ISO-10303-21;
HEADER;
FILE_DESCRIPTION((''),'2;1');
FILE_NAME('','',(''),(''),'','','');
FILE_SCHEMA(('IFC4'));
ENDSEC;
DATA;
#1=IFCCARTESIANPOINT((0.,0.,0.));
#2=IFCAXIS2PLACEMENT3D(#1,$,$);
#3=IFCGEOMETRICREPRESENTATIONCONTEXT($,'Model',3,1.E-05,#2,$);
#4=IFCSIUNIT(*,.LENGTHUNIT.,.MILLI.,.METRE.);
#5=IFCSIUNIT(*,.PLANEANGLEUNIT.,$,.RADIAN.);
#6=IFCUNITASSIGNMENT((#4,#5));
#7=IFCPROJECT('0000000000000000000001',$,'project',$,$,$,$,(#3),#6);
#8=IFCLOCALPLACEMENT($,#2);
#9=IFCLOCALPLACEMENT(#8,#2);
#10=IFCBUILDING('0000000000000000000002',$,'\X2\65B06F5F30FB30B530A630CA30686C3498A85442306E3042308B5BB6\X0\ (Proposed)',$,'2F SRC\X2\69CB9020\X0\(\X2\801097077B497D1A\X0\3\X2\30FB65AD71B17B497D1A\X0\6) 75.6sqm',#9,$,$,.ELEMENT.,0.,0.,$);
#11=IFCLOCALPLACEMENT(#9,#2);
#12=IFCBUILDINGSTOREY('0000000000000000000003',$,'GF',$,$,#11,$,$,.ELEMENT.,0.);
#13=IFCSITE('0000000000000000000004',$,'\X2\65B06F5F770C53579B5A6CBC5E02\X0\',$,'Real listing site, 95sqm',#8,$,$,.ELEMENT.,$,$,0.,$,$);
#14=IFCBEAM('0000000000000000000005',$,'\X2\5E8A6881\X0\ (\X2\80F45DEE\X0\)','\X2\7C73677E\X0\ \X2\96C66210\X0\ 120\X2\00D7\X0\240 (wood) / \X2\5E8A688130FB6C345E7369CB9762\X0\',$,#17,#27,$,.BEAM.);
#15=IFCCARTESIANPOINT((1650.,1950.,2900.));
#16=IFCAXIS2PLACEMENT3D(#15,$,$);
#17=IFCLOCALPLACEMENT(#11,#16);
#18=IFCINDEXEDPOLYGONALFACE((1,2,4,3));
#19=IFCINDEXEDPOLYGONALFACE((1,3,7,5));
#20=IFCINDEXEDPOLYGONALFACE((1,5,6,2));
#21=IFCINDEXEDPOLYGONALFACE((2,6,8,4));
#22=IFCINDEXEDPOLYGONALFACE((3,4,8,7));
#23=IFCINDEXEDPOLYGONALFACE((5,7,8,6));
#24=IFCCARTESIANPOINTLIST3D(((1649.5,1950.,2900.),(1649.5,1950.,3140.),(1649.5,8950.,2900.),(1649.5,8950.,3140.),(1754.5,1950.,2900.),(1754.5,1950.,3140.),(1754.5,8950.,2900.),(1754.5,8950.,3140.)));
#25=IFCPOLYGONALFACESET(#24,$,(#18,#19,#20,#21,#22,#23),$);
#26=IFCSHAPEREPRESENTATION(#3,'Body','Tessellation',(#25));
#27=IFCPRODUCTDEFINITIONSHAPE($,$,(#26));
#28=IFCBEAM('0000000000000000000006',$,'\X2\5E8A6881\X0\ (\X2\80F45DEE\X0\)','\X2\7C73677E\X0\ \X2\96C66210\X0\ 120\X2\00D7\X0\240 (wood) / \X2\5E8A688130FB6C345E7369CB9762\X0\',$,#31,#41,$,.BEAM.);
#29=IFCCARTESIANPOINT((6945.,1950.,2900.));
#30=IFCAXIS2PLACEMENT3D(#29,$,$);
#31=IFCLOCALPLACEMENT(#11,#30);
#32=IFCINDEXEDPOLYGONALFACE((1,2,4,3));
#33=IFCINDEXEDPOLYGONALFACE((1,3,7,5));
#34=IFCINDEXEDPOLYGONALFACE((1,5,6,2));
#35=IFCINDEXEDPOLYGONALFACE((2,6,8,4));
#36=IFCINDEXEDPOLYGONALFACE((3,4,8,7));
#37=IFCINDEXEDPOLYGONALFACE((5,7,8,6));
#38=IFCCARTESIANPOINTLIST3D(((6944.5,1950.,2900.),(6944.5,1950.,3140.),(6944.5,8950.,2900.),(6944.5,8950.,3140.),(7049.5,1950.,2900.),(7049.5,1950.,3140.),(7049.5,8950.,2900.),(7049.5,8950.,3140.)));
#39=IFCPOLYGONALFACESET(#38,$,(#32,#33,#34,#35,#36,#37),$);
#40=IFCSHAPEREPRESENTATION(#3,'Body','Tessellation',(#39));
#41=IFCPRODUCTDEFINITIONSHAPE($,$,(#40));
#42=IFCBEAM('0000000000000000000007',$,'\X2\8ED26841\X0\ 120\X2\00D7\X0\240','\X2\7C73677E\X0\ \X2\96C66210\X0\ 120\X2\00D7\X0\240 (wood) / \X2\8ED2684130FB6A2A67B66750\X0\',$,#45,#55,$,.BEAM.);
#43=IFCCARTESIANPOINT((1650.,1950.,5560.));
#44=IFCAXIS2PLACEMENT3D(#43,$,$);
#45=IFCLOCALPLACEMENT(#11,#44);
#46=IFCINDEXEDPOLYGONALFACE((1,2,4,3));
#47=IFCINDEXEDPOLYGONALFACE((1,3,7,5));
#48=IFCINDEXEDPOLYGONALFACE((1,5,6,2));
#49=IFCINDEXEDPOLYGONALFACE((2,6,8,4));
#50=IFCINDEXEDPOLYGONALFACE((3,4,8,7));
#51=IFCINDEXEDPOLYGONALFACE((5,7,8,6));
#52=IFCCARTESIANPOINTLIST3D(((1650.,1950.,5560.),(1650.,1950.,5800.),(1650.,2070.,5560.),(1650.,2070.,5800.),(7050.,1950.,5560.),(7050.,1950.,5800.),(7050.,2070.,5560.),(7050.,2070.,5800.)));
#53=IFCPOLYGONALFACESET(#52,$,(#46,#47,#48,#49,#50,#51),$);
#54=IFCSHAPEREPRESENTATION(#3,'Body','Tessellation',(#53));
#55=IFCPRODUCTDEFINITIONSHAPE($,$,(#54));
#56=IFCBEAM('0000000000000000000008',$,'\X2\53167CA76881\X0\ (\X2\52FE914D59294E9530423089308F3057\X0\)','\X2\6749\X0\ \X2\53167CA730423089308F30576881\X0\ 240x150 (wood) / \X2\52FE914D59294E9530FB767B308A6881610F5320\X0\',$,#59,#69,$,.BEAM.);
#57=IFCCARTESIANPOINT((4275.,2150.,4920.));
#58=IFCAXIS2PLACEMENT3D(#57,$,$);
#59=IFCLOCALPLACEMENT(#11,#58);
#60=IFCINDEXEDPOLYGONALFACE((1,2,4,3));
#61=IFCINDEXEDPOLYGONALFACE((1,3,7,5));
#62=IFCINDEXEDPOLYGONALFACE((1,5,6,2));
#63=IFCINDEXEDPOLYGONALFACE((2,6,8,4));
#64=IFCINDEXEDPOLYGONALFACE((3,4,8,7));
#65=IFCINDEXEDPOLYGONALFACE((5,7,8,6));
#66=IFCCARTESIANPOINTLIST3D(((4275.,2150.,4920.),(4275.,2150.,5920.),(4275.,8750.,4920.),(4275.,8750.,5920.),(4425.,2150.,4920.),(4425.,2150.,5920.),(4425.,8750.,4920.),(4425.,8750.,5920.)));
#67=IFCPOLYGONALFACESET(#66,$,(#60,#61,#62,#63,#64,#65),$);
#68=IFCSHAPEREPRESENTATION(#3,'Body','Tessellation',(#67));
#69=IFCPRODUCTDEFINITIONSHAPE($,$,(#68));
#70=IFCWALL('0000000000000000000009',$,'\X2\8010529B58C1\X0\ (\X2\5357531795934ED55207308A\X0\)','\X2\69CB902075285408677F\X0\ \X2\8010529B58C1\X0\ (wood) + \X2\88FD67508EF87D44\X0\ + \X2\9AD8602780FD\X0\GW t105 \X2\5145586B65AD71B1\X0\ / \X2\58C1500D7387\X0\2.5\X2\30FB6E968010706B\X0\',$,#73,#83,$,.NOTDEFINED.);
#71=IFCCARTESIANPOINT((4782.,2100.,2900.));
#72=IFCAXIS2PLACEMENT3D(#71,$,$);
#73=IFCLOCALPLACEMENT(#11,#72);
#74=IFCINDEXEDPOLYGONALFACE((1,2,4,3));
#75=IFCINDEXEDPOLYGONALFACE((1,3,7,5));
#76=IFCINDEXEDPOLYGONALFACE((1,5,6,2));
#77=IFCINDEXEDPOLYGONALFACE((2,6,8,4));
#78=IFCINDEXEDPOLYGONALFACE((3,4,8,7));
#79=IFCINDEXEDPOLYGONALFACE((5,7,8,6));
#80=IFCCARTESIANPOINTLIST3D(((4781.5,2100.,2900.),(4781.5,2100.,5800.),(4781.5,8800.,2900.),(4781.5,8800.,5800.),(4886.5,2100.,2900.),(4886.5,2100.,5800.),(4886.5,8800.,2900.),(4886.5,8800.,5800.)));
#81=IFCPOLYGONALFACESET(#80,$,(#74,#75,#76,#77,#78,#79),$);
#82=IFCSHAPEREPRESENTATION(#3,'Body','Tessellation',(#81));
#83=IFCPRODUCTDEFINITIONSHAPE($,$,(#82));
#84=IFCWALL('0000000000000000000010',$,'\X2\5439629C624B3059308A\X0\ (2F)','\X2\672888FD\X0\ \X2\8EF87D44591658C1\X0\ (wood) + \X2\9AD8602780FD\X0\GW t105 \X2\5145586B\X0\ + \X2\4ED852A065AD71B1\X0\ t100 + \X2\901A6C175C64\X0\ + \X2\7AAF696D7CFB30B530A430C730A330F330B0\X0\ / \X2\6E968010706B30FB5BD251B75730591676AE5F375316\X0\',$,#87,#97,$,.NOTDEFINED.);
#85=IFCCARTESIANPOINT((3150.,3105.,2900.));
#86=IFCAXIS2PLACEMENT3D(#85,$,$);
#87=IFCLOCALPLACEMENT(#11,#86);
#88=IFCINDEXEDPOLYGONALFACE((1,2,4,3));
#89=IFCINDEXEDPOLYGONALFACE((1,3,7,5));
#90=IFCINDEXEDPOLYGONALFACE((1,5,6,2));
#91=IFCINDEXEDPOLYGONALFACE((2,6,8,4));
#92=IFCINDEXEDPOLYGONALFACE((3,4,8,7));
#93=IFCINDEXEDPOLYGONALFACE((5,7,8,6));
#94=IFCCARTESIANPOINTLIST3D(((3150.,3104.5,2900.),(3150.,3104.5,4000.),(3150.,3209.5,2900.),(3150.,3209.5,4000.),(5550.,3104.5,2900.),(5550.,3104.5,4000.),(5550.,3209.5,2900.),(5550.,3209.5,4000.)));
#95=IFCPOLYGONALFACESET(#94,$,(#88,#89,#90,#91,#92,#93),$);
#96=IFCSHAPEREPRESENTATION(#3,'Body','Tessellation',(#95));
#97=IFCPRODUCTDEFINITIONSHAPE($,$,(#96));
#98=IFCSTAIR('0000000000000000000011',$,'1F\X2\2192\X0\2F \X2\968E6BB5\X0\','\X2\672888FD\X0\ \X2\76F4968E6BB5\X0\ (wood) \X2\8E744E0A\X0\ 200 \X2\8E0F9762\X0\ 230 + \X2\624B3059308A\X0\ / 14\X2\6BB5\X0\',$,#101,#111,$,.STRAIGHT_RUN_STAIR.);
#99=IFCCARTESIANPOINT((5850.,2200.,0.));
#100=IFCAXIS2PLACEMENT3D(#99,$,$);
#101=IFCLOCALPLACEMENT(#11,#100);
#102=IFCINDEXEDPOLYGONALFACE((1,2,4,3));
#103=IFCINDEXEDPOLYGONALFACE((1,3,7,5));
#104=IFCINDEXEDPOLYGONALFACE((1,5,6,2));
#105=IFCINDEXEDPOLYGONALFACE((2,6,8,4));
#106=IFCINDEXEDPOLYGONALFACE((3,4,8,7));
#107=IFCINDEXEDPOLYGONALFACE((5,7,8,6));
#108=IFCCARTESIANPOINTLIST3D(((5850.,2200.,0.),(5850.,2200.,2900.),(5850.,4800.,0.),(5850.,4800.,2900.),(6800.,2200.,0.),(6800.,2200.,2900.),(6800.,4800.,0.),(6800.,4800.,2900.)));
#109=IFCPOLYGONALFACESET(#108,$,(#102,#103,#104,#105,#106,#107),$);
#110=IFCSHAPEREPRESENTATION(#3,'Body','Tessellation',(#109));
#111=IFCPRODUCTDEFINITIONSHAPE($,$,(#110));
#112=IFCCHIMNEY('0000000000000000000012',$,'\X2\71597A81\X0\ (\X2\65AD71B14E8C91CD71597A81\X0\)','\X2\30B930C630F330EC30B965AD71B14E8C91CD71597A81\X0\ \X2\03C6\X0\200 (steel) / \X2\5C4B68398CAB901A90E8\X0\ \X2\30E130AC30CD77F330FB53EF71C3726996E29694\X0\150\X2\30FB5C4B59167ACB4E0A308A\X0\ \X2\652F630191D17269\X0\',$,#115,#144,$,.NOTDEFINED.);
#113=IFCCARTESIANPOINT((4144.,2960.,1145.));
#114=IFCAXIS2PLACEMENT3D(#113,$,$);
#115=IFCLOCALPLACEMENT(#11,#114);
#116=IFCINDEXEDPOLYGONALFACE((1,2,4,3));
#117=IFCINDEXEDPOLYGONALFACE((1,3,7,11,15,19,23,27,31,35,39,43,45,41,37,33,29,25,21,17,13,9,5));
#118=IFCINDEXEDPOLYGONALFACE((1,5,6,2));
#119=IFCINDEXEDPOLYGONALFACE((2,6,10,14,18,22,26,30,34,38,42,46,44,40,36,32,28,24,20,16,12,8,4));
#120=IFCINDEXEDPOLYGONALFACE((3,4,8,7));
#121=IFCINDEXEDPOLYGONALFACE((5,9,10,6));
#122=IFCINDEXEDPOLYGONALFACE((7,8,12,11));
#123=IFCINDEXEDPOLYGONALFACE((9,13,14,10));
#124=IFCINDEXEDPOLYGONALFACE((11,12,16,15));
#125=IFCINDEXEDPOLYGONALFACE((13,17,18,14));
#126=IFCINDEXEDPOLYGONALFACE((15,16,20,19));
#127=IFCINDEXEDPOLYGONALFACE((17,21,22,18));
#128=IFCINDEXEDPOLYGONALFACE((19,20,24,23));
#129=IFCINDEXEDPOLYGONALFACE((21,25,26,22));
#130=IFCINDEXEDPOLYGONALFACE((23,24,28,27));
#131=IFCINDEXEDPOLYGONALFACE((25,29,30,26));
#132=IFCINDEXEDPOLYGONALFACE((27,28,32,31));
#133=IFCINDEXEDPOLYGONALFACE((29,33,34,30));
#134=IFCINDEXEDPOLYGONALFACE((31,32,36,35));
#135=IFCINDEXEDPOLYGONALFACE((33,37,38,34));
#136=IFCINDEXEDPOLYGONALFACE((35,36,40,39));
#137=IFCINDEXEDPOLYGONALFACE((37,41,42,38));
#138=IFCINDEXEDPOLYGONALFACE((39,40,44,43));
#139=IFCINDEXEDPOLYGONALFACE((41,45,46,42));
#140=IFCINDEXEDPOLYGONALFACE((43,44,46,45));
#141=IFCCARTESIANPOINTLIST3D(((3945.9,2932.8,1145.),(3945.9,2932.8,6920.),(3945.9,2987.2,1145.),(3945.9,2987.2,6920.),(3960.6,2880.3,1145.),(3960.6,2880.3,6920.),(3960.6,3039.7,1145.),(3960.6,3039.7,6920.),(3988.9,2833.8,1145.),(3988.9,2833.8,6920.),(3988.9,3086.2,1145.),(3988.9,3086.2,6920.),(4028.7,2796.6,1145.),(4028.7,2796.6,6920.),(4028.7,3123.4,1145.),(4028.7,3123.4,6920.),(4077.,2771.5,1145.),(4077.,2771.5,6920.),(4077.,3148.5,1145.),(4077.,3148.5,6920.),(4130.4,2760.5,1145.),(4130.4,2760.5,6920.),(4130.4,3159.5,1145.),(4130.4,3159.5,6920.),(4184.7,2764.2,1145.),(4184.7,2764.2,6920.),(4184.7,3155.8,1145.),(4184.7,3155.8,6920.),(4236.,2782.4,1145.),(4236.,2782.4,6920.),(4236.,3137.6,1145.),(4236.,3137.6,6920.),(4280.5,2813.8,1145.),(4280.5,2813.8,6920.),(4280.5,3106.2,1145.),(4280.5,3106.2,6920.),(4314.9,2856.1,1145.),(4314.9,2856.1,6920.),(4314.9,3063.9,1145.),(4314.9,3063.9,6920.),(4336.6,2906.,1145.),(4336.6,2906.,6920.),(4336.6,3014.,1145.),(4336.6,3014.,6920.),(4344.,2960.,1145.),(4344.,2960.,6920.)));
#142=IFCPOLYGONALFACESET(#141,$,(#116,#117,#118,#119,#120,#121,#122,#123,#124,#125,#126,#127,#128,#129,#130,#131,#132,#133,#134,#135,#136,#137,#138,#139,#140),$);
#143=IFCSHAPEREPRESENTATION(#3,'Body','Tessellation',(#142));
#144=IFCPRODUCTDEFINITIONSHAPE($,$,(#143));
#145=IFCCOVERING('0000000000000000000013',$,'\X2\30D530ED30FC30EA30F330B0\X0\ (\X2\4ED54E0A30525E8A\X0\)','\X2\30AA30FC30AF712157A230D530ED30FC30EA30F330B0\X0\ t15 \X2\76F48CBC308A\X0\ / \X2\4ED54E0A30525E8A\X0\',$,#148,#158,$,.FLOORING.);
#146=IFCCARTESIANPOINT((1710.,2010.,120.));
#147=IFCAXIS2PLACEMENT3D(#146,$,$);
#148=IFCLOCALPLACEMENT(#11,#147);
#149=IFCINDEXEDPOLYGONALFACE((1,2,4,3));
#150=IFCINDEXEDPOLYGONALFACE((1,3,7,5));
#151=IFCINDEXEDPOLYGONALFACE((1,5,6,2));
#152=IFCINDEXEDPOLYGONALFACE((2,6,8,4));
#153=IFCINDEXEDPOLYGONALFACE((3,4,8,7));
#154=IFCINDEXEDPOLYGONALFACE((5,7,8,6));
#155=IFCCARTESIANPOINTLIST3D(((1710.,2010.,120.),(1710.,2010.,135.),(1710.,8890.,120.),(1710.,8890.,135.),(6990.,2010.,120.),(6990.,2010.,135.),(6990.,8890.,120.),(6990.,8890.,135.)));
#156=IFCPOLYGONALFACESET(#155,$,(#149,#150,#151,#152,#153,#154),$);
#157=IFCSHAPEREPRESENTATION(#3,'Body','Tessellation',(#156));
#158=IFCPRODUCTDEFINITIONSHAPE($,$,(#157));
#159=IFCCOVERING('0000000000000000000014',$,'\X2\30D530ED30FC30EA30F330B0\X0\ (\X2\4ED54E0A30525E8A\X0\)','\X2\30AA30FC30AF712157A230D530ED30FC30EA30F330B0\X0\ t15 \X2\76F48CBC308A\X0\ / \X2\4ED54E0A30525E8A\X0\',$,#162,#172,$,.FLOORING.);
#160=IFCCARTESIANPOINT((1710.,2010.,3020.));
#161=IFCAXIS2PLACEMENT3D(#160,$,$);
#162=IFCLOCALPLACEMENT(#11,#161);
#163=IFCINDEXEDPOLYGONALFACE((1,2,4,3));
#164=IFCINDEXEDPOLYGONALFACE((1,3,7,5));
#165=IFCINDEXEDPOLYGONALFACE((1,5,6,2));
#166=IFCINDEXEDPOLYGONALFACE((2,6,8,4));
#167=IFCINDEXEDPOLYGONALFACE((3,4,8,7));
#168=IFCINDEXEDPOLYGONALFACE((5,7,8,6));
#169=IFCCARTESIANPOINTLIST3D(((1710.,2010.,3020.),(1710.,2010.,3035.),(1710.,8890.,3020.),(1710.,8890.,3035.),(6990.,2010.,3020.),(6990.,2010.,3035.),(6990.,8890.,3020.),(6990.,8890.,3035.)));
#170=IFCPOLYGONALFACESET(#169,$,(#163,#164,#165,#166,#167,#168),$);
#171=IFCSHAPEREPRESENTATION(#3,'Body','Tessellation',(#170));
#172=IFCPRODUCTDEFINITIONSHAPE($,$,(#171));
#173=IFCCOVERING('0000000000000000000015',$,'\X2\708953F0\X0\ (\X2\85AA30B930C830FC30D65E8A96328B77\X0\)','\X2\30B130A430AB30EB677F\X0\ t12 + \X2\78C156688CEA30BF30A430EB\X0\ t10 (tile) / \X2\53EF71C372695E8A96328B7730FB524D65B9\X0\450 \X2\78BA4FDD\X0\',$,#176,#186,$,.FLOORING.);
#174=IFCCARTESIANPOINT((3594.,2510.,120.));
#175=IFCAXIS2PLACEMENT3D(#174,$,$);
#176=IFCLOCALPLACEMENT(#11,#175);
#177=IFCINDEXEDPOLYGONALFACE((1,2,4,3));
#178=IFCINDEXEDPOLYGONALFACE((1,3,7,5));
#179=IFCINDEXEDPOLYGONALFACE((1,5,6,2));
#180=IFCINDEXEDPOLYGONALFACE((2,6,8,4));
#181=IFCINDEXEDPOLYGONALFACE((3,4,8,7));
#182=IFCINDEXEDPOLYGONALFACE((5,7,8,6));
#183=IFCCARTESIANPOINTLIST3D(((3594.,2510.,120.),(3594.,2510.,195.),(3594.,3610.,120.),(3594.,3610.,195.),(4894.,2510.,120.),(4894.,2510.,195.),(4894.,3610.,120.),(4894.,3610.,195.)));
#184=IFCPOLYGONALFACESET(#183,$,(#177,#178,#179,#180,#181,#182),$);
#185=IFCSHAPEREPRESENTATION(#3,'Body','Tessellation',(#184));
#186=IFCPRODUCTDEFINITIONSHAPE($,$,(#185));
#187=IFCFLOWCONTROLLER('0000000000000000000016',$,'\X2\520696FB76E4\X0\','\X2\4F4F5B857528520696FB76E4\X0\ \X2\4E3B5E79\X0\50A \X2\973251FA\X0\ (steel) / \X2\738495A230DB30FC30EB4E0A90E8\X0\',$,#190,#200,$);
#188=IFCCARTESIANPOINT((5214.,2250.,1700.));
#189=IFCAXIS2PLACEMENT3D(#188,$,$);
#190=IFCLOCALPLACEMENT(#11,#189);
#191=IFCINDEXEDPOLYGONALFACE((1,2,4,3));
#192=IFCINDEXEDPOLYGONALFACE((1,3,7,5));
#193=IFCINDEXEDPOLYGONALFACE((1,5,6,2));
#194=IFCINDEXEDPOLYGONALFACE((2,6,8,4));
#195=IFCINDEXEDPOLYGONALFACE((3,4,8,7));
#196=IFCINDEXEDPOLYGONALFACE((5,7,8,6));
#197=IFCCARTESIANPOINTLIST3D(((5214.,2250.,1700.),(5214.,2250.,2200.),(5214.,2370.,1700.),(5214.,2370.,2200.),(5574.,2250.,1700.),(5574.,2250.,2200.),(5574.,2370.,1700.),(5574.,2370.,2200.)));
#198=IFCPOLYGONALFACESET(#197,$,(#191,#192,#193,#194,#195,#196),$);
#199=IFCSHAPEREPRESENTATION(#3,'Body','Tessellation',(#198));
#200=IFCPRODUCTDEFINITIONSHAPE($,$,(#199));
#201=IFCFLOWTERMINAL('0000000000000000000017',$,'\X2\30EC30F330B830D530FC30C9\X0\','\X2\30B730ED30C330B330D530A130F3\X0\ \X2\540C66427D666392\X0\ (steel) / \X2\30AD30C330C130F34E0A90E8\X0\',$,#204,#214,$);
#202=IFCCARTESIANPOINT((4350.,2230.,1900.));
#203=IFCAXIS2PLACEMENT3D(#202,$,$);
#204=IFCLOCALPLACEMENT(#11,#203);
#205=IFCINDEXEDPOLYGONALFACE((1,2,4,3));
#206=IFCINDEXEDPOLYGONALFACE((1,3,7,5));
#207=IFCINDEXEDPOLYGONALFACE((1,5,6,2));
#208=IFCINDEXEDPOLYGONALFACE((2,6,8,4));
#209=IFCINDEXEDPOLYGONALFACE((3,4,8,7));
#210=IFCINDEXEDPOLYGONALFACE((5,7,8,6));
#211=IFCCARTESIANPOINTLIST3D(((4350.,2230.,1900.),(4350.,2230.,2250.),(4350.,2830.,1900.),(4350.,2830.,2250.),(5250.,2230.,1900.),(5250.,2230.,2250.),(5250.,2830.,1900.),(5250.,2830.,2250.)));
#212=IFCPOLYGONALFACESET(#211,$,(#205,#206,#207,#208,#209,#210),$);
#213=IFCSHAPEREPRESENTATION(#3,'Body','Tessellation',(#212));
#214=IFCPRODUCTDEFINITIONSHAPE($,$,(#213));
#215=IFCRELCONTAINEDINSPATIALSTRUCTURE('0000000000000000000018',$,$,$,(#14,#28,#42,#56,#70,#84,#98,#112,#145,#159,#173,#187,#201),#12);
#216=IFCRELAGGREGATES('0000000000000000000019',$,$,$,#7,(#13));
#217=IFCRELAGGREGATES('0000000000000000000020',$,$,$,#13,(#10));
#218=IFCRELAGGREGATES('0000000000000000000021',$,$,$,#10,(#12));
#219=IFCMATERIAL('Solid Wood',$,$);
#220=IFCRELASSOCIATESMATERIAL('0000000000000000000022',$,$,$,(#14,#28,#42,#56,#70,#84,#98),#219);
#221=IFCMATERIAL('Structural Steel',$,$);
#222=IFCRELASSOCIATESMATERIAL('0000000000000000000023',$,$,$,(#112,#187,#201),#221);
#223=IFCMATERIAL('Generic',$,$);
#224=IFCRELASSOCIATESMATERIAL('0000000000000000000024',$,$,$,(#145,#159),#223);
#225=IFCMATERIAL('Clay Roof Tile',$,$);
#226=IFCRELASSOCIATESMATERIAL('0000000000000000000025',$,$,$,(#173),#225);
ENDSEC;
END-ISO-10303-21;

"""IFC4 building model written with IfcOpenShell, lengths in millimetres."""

from ifc_helpers import new_model, si_unit, frame, frame_2d, origin, origin_2d, place, context, project, spatial, rectangle, circle, extrude, material, element, save


model = new_model("IFC4")

# Units and contexts
model_context = context("Model", 3, precision=1e-05, world=origin())
ifc_project = project(units=[si_unit("LENGTHUNIT", "METRE", prefix="MILLI"), si_unit("PLANEANGLEUNIT", "RADIAN")], contexts=[model_context])

# Site, building, storey
site_placement = place(None, origin())
site = spatial("IfcSite", under=ifc_project, at=site_placement, Name="新潟県南魚沼市", ObjectType="Real listing site, 95sqm", CompositionType="ELEMENT", RefElevation=0.0)
building_placement = place(site_placement, origin())
building = spatial("IfcBuilding", under=site, at=building_placement, Name="新潟・サウナと水風呂のある家 (Proposed)", ObjectType="2F SRC構造(耐震等級3・断熱等級6) 75.6sqm", CompositionType="ELEMENT", ElevationOfRefHeight=0.0, ElevationOfTerrain=0.0)
storey_placement = place(building_placement, origin())
storey = spatial("IfcBuildingStorey", under=building, at=storey_placement, Name="GF", CompositionType="ELEMENT", Elevation=0.0)

# Beams
ifc_material_1 = material(Name="Solid Wood")
beam_1_placement = place(storey_placement, frame((1650.0, 1950.0, 2900.0)))
element("IfcBeam", 1, at=beam_1_placement, inside=storey, material=ifc_material_1, Name="床梁 (胴差)", Description="米松 集成 120×240 (wood) / 床梁・水平構面", PredefinedType="BEAM", context=model_context, shape_type="SweptSolid", body=[
    extrude(rectangle(XDim=105.0, YDim=7000.0, at=frame_2d((52.0, 3500.0))), frame((1650.0, 1950.0, 2900.0)), (0.0, 0.0, 1.0), 240.0),
])
beam_2_placement = place(storey_placement, frame((6945.0, 1950.0, 2900.0)))
element("IfcBeam", 2, at=beam_2_placement, inside=storey, material=ifc_material_1, Name="床梁 (胴差)", Description="米松 集成 120×240 (wood) / 床梁・水平構面", PredefinedType="BEAM", context=model_context, shape_type="SweptSolid", body=[
    extrude(rectangle(XDim=105.0, YDim=7000.0, at=frame_2d((52.0, 3500.0))), frame((6945.0, 1950.0, 2900.0)), (0.0, 0.0, 1.0), 240.0),
])
beam_3_placement = place(storey_placement, frame((1650.0, 1950.0, 5560.0)))
element("IfcBeam", 3, at=beam_3_placement, inside=storey, material=ifc_material_1, Name="軒桁 120×240", Description="米松 集成 120×240 (wood) / 軒桁・横架材", PredefinedType="BEAM", context=model_context, shape_type="SweptSolid", body=[
    extrude(rectangle(XDim=5400.0, YDim=120.0, at=frame_2d((2700.0, 60.0))), frame((1650.0, 1950.0, 5560.0)), (0.0, 0.0, 1.0), 240.0),
])
beam_4_placement = place(storey_placement, frame((4275.0, 2150.0, 4920.0)))
element("IfcBeam", 4, at=beam_4_placement, inside=storey, material=ifc_material_1, Name="化粧梁 (勾配天井あらわし)", Description="杉 化粧あらわし梁 240x150 (wood) / 勾配天井・登り梁意匠", PredefinedType="BEAM", context=model_context, shape_type="SweptSolid", body=[
    extrude(rectangle(XDim=150.0, YDim=6600.0, at=frame_2d((75.0, 3300.0))), frame((4275.0, 2150.0, 4920.0)), (0.0, 0.0, 1.0), 1000.0),
])

# Walls
wall_1_placement = place(storey_placement, frame((4782.0, 2100.0, 2900.0)))
element("IfcWall", 5, at=wall_1_placement, inside=storey, material=ifc_material_1, Name="耐力壁 (南北間仕切り)", Description="構造用合板 耐力壁 (wood) + 製材軸組 + 高性能GW t105 充填断熱 / 壁倍率2.5・準耐火", PredefinedType="NOTDEFINED", context=model_context, shape_type="SweptSolid", body=[
    extrude(rectangle(XDim=105.0, YDim=6700.0, at=frame_2d((52.0, 3350.0))), frame((4782.0, 2100.0, 2900.0)), (0.0, 0.0, 1.0), 2900.0),
])
wall_2_placement = place(storey_placement, frame((3150.0, 3105.0, 2900.0)))
element("IfcWall", 6, at=wall_2_placement, inside=storey, material=ifc_material_1, Name="吹抜手すり (2F)", Description="木製 軸組外壁 (wood) + 高性能GW t105 充填 + 付加断熱 t100 + 通気層 + 窯業系サイディング / 準耐火・寒冷地外皮強化", PredefinedType="NOTDEFINED", context=model_context, shape_type="SweptSolid", body=[
    extrude(rectangle(XDim=2400.0, YDim=105.0, at=frame_2d((1200.0, 52.0))), frame((3150.0, 3105.0, 2900.0)), (0.0, 0.0, 1.0), 1100.0),
])

# Stair
stair_placement = place(storey_placement, frame((5850.0, 2200.0, 0.0)))
element("IfcStair", 7, at=stair_placement, inside=storey, material=ifc_material_1, Name="1F→2F 階段", Description="木製 直階段 (wood) 蹴上 200 踏面 230 + 手すり / 14段", PredefinedType="STRAIGHT_RUN_STAIR", context=model_context, shape_type="SweptSolid", body=[
    extrude(rectangle(XDim=950.0, YDim=2600.0, at=frame_2d((475.0, 1300.0))), frame((5850.0, 2200.0, 0.0)), (0.0, 0.0, 1.0), 2900.0),
])

# Chimney
ifc_material_2 = material(Name="Structural Steel")
chimney_placement = place(storey_placement, frame((4144.0, 2960.0, 1145.0)))
element("IfcChimney", 8, at=chimney_placement, inside=storey, material=ifc_material_2, Name="煙突 (断熱二重煙突)", Description="ステンレス断熱二重煙突 φ200 (steel) / 屋根貫通部 メガネ石・可燃物離隔150・屋外立上り 支持金物", PredefinedType="NOTDEFINED", context=model_context, shape_type="SweptSolid", body=[
    extrude(circle(Radius=200.0, at=origin_2d()), frame((4144.0, 2960.0, 1145.0)), (0.0, 0.0, 1.0), 5775.0),
])

# Coverings
ifc_material_3 = material(Name="Generic")
covering_1_placement = place(storey_placement, frame((1710.0, 2010.0, 120.0)))
element("IfcCovering", 9, at=covering_1_placement, inside=storey, material=ifc_material_3, Name="フローリング (仕上げ床)", Description="オーク無垢フローリング t15 直貼り / 仕上げ床", PredefinedType="FLOORING", context=model_context, shape_type="SweptSolid", body=[
    extrude(rectangle(XDim=5280.0, YDim=6880.0, at=frame_2d((2640.0, 3440.0))), frame((1710.0, 2010.0, 120.0)), (0.0, 0.0, 1.0), 15.0),
])
covering_2_placement = place(storey_placement, frame((1710.0, 2010.0, 3020.0)))
element("IfcCovering", 10, at=covering_2_placement, inside=storey, material=ifc_material_3, Name="フローリング (仕上げ床)", Description="オーク無垢フローリング t15 直貼り / 仕上げ床", PredefinedType="FLOORING", context=model_context, shape_type="SweptSolid", body=[
    extrude(rectangle(XDim=5280.0, YDim=6880.0, at=frame_2d((2640.0, 3440.0))), frame((1710.0, 2010.0, 3020.0)), (0.0, 0.0, 1.0), 15.0),
])
ifc_material_4 = material(Name="Clay Roof Tile")
covering_3_placement = place(storey_placement, frame((3594.0, 2510.0, 120.0)))
element("IfcCovering", 11, at=covering_3_placement, inside=storey, material=ifc_material_4, Name="炉台 (薪ストーブ床防護)", Description="ケイカル板 t12 + 磁器質タイル t10 (tile) / 可燃物床防護・前方450 確保", PredefinedType="FLOORING", context=model_context, shape_type="SweptSolid", body=[
    extrude(rectangle(XDim=1300.0, YDim=1100.0, at=frame_2d((650.0, 550.0))), frame((3594.0, 2510.0, 120.0)), (0.0, 0.0, 1.0), 75.0),
])

# Flow controller
flow_controller_placement = place(storey_placement, frame((5214.0, 2250.0, 1700.0)))
element("IfcFlowController", 12, at=flow_controller_placement, inside=storey, material=ifc_material_2, Name="分電盤", Description="住宅用分電盤 主幹50A 露出 (steel) / 玄関ホール上部", context=model_context, shape_type="SweptSolid", body=[
    extrude(rectangle(XDim=360.0, YDim=120.0, at=frame_2d((180.0, 60.0))), frame((5214.0, 2250.0, 1700.0)), (0.0, 0.0, 1.0), 500.0),
])

# Flow terminal
flow_terminal_1_placement = place(storey_placement, frame((4350.0, 2230.0, 1900.0)))
element("IfcFlowTerminal", 13, at=flow_terminal_1_placement, inside=storey, material=ifc_material_2, Name="レンジフード", Description="シロッコファン 同時給排 (steel) / キッチン上部", context=model_context, shape_type="SweptSolid", body=[
    extrude(rectangle(XDim=900.0, YDim=600.0, at=frame_2d((450.0, 300.0))), frame((4350.0, 2230.0, 1900.0)), (0.0, 0.0, 1.0), 350.0),
])

save(model, "model.ifc")
